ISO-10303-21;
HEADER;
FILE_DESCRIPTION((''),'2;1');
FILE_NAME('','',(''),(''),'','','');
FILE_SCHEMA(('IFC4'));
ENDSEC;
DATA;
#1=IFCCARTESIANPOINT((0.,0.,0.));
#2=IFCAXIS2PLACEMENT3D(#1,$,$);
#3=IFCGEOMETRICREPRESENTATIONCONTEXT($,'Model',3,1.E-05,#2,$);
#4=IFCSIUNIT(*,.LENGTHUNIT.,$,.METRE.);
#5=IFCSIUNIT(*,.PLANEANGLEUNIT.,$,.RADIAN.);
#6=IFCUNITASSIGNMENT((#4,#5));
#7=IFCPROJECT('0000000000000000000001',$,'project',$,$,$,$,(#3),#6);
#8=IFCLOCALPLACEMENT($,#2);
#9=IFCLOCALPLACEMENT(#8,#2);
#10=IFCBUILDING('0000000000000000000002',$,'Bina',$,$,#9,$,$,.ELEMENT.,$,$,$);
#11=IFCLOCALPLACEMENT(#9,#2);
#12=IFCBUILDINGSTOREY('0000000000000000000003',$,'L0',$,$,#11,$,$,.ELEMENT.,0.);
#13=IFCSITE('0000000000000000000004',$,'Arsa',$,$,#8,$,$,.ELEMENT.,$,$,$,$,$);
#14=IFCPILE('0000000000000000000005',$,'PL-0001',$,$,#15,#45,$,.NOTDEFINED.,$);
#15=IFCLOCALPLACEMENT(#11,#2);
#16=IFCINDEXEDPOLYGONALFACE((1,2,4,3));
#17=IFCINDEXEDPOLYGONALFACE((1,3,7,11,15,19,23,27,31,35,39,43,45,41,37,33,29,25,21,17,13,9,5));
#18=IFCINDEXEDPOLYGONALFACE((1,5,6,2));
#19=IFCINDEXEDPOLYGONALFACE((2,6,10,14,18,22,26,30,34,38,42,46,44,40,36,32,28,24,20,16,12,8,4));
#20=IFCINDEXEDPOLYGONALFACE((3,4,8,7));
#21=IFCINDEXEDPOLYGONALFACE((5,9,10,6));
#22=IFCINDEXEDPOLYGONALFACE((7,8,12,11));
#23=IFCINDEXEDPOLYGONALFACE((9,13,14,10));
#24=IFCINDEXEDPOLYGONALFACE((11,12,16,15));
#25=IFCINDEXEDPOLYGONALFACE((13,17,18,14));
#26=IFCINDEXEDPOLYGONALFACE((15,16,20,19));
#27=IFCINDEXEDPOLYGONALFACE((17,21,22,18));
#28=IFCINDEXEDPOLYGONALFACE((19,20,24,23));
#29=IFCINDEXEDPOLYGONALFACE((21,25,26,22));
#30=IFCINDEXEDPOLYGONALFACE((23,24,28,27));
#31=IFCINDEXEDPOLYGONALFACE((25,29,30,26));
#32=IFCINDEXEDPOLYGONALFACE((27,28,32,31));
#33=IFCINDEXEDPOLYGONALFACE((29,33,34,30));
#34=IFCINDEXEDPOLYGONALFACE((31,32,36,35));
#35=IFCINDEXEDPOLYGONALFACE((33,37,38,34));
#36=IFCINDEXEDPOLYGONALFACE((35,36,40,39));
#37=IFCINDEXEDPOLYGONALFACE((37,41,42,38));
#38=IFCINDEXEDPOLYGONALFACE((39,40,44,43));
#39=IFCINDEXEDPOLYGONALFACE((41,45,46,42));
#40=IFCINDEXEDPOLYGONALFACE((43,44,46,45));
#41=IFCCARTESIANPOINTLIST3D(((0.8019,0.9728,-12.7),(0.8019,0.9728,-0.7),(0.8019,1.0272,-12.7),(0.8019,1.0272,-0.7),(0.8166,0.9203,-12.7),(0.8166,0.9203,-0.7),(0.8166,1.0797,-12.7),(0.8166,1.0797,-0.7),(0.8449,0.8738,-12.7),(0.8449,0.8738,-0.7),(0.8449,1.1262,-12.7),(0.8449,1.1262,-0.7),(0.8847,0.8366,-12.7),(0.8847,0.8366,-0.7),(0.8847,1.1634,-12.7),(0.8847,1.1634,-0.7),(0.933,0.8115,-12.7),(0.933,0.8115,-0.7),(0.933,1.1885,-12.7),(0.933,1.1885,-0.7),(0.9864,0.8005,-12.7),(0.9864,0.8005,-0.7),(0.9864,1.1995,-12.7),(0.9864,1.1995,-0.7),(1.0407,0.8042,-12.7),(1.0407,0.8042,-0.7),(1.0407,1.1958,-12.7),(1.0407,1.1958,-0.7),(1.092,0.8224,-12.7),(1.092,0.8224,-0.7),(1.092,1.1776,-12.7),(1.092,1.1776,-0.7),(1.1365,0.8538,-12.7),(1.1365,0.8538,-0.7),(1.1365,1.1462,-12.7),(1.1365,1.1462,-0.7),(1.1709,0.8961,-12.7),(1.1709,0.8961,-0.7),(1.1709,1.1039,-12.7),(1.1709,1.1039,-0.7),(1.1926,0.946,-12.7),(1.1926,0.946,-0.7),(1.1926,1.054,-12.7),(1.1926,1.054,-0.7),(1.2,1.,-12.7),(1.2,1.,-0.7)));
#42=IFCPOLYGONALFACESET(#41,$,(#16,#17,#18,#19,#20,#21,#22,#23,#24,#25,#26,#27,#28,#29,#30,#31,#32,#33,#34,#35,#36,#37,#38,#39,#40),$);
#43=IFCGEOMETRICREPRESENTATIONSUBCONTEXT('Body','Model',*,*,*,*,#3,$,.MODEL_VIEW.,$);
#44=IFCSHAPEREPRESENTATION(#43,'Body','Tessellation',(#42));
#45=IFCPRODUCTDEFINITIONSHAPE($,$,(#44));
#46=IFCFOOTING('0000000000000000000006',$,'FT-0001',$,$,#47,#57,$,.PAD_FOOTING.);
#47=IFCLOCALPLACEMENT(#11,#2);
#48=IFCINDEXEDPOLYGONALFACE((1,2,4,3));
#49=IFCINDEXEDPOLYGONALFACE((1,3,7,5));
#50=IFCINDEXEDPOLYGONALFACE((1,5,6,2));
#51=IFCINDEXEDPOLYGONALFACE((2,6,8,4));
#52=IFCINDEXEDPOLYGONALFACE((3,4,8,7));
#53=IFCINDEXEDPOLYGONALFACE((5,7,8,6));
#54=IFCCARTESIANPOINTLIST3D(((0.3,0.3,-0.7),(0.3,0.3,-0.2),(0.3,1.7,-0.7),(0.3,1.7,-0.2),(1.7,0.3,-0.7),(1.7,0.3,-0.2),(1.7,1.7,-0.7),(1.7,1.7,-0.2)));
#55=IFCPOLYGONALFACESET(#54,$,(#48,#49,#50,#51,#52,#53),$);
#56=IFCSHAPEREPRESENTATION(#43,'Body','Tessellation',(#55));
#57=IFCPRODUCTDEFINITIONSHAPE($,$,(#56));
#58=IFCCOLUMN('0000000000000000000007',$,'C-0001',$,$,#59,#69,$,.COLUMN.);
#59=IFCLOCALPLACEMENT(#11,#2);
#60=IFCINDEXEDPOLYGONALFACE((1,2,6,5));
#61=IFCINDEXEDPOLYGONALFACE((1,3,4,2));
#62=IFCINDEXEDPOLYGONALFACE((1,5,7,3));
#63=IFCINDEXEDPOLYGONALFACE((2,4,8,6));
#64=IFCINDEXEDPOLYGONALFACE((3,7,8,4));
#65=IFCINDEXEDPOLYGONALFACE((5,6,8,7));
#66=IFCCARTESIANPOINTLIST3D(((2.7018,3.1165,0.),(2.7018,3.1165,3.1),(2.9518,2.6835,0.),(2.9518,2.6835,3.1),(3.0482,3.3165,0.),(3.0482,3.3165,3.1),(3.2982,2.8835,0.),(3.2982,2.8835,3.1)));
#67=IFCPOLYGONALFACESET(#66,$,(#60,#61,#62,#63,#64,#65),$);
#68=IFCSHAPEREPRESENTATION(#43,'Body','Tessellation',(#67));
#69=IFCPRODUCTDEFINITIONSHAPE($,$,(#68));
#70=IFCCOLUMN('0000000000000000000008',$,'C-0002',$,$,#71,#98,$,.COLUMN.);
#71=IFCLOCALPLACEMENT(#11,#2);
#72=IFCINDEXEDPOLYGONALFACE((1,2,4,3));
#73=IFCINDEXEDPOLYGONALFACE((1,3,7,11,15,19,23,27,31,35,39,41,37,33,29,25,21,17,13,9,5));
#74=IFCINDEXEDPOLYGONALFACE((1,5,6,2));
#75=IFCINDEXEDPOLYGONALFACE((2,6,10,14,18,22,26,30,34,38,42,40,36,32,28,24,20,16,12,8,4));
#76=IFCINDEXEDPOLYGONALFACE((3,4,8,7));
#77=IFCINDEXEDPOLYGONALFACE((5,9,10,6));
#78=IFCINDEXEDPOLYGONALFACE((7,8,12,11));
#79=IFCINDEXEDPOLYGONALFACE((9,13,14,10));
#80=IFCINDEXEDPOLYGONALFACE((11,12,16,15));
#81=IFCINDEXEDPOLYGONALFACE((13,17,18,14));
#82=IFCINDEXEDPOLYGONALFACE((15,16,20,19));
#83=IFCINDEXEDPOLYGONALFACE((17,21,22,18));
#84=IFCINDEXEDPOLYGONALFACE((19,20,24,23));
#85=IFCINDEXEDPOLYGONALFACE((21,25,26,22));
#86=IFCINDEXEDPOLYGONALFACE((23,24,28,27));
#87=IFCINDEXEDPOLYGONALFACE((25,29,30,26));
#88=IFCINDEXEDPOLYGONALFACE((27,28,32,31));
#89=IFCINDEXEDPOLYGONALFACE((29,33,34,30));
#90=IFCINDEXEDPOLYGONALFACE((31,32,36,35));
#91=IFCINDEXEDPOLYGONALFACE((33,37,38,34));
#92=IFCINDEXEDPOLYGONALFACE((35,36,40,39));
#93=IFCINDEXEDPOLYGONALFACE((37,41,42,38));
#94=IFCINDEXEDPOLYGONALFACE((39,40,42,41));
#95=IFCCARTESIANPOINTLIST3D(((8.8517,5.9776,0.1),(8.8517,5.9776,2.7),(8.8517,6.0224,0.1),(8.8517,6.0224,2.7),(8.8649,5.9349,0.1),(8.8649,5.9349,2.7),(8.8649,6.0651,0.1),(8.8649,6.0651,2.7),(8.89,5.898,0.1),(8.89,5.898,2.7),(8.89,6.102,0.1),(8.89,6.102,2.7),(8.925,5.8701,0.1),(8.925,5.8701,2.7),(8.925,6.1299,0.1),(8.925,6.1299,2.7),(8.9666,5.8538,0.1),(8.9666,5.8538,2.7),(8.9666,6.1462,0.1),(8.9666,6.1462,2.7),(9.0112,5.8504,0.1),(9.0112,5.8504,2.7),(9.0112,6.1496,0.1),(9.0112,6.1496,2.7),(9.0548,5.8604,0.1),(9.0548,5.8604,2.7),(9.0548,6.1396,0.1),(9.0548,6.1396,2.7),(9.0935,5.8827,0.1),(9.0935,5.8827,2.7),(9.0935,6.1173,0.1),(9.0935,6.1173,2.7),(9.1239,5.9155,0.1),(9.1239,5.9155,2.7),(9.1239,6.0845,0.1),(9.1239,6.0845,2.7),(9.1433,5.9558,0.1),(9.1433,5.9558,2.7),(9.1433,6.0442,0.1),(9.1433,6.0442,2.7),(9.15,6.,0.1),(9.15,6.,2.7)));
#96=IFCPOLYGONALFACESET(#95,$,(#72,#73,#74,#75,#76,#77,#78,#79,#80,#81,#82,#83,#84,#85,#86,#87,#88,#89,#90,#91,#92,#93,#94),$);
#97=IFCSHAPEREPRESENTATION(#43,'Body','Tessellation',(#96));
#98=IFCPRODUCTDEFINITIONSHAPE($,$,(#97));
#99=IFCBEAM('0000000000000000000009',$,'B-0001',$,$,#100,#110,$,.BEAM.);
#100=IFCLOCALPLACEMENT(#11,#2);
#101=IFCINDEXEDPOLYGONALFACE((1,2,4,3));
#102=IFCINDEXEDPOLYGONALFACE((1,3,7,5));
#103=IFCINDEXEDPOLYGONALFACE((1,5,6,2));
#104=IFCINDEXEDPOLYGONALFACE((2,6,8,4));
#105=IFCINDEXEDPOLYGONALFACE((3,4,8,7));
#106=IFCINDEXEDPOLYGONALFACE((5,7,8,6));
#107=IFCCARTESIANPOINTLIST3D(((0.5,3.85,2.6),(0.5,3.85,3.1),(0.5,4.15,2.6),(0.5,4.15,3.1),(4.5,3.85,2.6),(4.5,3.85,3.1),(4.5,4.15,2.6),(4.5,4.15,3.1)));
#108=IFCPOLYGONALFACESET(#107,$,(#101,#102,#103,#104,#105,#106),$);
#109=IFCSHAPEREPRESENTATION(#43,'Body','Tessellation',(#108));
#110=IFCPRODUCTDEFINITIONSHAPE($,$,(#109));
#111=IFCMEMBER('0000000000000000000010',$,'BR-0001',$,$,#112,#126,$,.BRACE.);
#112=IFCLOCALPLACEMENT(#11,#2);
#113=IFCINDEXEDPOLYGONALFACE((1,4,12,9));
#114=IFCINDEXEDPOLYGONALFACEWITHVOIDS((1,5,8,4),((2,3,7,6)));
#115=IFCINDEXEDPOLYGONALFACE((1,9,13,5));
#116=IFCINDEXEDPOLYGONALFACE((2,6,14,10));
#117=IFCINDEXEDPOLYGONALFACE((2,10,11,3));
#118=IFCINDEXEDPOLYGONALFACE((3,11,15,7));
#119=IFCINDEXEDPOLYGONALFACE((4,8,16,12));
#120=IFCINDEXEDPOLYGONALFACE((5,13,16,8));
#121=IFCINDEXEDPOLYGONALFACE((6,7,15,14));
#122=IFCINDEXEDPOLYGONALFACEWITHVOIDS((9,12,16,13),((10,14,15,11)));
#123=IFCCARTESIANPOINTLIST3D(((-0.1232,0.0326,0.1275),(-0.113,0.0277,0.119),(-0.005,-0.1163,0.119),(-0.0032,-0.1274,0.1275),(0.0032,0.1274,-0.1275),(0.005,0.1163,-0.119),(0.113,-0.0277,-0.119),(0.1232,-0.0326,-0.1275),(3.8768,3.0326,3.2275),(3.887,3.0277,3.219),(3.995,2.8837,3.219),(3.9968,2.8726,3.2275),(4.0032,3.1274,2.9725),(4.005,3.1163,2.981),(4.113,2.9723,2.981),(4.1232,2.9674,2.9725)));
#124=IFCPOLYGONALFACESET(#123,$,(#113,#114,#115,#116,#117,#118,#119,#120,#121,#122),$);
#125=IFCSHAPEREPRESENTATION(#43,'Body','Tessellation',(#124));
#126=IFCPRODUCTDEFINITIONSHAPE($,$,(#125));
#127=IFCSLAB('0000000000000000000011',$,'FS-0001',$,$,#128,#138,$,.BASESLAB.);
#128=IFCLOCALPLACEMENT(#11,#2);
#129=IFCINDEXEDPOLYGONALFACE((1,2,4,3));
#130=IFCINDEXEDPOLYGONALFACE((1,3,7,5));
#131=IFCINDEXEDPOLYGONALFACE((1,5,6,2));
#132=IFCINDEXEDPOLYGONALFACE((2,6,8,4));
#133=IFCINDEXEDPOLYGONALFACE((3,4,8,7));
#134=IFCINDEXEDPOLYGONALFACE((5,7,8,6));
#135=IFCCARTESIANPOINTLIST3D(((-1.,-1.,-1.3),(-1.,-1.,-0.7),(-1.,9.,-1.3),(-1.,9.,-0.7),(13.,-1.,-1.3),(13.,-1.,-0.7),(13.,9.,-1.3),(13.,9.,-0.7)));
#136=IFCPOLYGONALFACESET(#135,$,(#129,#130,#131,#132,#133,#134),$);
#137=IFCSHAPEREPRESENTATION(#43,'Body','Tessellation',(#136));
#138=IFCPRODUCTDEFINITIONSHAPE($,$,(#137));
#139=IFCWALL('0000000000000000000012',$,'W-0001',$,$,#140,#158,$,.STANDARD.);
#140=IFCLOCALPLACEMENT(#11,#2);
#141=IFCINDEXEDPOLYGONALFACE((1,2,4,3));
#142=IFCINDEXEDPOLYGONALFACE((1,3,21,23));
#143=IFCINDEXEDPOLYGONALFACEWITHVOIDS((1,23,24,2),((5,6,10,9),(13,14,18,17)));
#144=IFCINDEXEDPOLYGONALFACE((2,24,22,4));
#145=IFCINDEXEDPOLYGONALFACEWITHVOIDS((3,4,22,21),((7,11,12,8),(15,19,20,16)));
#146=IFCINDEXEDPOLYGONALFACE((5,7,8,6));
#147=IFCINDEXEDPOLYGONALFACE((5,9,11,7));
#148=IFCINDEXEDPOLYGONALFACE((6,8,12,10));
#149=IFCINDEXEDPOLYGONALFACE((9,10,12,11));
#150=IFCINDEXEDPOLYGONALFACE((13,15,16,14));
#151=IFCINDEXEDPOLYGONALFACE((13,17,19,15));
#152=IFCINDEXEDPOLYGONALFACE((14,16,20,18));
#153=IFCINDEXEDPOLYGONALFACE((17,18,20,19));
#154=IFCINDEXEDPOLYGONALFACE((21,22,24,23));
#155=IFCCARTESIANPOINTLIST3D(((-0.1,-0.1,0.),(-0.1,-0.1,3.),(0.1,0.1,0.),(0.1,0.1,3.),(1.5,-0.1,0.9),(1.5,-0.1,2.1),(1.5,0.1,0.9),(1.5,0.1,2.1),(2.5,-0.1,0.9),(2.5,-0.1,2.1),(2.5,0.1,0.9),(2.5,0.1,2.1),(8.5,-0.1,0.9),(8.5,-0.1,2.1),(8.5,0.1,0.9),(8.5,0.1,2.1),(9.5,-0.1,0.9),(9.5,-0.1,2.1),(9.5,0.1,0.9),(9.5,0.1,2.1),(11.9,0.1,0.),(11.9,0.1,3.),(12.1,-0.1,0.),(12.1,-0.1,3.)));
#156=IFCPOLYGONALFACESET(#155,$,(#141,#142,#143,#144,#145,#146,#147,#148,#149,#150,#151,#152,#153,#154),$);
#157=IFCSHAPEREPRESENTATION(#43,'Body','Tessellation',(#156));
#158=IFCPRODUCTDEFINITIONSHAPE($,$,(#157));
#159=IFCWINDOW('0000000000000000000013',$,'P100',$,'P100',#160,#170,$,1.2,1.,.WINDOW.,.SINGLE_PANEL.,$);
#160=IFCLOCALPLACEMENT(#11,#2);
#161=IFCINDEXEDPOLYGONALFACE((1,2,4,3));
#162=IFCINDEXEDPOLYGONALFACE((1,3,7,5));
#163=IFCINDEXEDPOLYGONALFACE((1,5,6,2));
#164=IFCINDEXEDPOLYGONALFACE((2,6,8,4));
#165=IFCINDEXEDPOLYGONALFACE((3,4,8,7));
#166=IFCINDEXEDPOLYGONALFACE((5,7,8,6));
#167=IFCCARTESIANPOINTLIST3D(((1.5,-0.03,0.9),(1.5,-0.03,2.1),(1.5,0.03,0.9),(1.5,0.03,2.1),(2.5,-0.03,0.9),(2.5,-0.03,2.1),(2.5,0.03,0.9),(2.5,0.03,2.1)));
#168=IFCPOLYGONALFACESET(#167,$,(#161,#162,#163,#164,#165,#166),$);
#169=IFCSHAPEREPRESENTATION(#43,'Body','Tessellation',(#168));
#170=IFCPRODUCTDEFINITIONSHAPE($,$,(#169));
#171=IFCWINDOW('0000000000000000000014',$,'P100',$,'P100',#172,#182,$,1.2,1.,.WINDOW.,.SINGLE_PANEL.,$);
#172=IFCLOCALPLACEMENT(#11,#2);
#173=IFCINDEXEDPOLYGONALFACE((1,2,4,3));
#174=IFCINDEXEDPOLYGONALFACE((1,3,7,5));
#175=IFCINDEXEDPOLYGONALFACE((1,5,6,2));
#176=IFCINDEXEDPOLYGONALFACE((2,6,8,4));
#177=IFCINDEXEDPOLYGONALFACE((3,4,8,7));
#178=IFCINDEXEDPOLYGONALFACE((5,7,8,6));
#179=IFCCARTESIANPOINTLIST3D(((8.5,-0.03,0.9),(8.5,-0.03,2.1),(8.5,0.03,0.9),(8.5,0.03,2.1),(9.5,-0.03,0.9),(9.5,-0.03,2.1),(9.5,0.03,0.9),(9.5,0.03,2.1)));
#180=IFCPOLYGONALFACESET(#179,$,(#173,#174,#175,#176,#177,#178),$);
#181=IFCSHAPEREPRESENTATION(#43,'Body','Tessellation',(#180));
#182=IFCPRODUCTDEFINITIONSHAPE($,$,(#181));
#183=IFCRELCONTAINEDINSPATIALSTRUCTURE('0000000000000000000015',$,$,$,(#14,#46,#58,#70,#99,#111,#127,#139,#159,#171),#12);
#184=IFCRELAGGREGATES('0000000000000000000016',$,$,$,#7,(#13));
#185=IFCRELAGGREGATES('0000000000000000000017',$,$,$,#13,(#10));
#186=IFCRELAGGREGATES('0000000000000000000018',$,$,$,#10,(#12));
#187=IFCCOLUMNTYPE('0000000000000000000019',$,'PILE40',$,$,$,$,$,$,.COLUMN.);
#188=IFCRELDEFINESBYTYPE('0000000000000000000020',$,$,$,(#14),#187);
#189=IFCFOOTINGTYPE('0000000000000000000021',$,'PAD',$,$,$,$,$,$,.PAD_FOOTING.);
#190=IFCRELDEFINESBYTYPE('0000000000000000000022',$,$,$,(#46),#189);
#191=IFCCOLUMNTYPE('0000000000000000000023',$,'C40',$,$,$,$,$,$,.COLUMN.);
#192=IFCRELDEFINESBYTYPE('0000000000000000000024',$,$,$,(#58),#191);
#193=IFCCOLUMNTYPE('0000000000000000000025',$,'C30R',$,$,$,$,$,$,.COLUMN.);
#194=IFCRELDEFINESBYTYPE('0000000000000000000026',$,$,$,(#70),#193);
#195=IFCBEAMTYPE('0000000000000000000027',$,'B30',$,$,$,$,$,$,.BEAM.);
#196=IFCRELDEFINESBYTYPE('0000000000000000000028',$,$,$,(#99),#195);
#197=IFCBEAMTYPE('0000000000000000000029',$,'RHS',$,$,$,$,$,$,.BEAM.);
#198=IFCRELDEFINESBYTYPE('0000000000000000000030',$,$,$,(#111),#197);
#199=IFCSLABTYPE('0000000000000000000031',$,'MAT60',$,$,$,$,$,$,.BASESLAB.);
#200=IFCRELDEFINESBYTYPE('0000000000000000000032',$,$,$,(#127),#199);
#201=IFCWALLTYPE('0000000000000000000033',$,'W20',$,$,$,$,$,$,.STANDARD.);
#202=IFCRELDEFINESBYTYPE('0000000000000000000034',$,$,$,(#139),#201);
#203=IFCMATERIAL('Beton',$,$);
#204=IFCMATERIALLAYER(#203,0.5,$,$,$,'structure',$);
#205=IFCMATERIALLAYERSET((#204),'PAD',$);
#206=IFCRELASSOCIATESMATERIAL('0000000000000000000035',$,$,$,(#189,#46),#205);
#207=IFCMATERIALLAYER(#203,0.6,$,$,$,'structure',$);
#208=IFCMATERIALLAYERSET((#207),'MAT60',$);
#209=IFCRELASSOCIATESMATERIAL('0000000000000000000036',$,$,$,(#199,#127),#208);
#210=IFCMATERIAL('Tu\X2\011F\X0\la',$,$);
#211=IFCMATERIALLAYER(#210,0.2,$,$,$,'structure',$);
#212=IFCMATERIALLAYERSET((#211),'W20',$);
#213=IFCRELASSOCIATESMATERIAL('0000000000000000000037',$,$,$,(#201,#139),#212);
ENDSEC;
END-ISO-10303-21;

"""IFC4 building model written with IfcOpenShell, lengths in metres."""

from ifc_helpers import new_model, si_unit, frame, frame_2d, origin, origin_with_axes, origin_2d, place, context, subcontext, project, spatial, polyline, rectangle, hollow_rectangle, circle, outline, extrude, material, layer, layer_set, layer_usage, type_object, element, fill, save


model = new_model("IFC4")

# Units and contexts
model_context = context("Model", 3, precision=1e-05, world=origin())
body_context = subcontext(model_context, "Body", "Model", "MODEL_VIEW")
ifc_project = project(units=[si_unit("LENGTHUNIT", "METRE"), si_unit("PLANEANGLEUNIT", "RADIAN")], contexts=[model_context])

# Site, building, storey
site_placement = place(None, origin())
site = spatial("IfcSite", under=ifc_project, at=site_placement, Name="Arsa", CompositionType="ELEMENT")
building_placement = place(site_placement, origin())
building = spatial("IfcBuilding", under=site, at=building_placement, Name="Bina", CompositionType="ELEMENT")
storey_placement = place(building_placement, origin())
storey = spatial("IfcBuildingStorey", under=building, at=storey_placement, Name="L0", CompositionType="ELEMENT", Elevation=0.0)

# Pile
column_type_1 = type_object("IfcColumnType", Name="PILE40", PredefinedType="COLUMN")
pile_placement = place(storey_placement, origin())
element("IfcPile", 1, at=pile_placement, inside=storey, type_object=column_type_1, Name="PL-0001", PredefinedType="NOTDEFINED", context=body_context, shape_type="SweptSolid", body=[
    extrude(circle(Radius=0.2, at=origin_2d()), frame((1.0, 1.0, -0.7), z_axis=(0.0, 0.0, -1.0), x_axis=(1.0, 0.0, 0.0)), (0.0, 0.0, 1.0), 12.0),
])

# Footing
ifc_material_1 = material(Name="Beton")
ifc_layer_1 = layer(ifc_material_1, 0.5, Category="structure")
ifc_layer_set_1 = layer_set([ifc_layer_1], Name="PAD")
ifc_layer_usage_1 = layer_usage(ifc_layer_set_1, "AXIS3", "NEGATIVE", -0.2)
footing_type = type_object("IfcFootingType", Name="PAD", PredefinedType="PAD_FOOTING", material=ifc_layer_set_1)
footing_placement = place(storey_placement, origin())
element("IfcFooting", 2, at=footing_placement, inside=storey, type_object=footing_type, material=ifc_layer_usage_1, Name="FT-0001", PredefinedType="PAD_FOOTING", context=body_context, shape_type="SweptSolid", body=[
    extrude(outline(polyline([(0.3, 0.3), (1.7, 0.3), (1.7, 1.7), (0.3, 1.7), (0.3, 0.3)])), frame((0.0, 0.0, -0.7)), (0.0, 0.0, 1.0), 0.5),
])

# Columns
column_type_2 = type_object("IfcColumnType", Name="C40", PredefinedType="COLUMN")
column_1_placement = place(storey_placement, origin())
element("IfcColumn", 3, at=column_1_placement, inside=storey, type_object=column_type_2, Name="C-0001", PredefinedType="COLUMN", context=body_context, shape_type="SweptSolid", body=[
    extrude(rectangle(XDim=0.4, YDim=0.5, at=origin_2d()), frame((3.0, 3.0, 0.0), z_axis=(0.0, 0.0, 1.0), x_axis=(0.866025, 0.5, 0.0)), (0.0, 0.0, 1.0), 3.1),
])
column_type_3 = type_object("IfcColumnType", Name="C30R", PredefinedType="COLUMN")
column_2_placement = place(storey_placement, origin())
element("IfcColumn", 4, at=column_2_placement, inside=storey, type_object=column_type_3, Name="C-0002", PredefinedType="COLUMN", context=body_context, shape_type="SweptSolid", body=[
    extrude(circle(Radius=0.15, at=origin_2d()), frame((9.0, 6.0, 0.1), z_axis=(0.0, 0.0, 1.0), x_axis=(1.0, 0.0, 0.0)), (0.0, 0.0, 1.0), 2.6),
])

# Beam
beam_type_1 = type_object("IfcBeamType", Name="B30", PredefinedType="BEAM")
beam_placement = place(storey_placement, origin())
element("IfcBeam", 5, at=beam_placement, inside=storey, type_object=beam_type_1, Name="B-0001", PredefinedType="BEAM", context=body_context, shape_type="SweptSolid", body=[
    extrude(rectangle(XDim=0.3, YDim=0.5, at=frame_2d((0.0, -0.25))), frame((0.5, 4.0, 3.1), z_axis=(1.0, 0.0, 0.0), x_axis=(0.0, 1.0, 0.0)), (0.0, 0.0, 1.0), 4.0),
])

# Member
beam_type_2 = type_object("IfcBeamType", Name="RHS", PredefinedType="BEAM")
member_placement = place(storey_placement, origin())
element("IfcMember", 6, at=member_placement, inside=storey, type_object=beam_type_2, Name="BR-0001", PredefinedType="BRACE", context=body_context, shape_type="SweptSolid", body=[
    extrude(hollow_rectangle(XDim=0.2, YDim=0.3, WallThickness=0.01, at=origin_2d()), frame((0.0, 0.0, 0.0), z_axis=(0.679922, 0.509942, 0.52694), x_axis=(-0.6, 0.8, 0.0)), (0.0, 0.0, 1.0), 5.883),
])

# Slab
ifc_layer_2 = layer(ifc_material_1, 0.6, Category="structure")
ifc_layer_set_2 = layer_set([ifc_layer_2], Name="MAT60")
ifc_layer_usage_2 = layer_usage(ifc_layer_set_2, "AXIS3", "NEGATIVE", -0.7)
slab_type = type_object("IfcSlabType", Name="MAT60", PredefinedType="BASESLAB", material=ifc_layer_set_2)
slab_placement = place(storey_placement, origin())
element("IfcSlab", 7, at=slab_placement, inside=storey, type_object=slab_type, material=ifc_layer_usage_2, Name="FS-0001", PredefinedType="BASESLAB", context=body_context, shape_type="SweptSolid", body=[
    extrude(outline(polyline([(-1.0, -1.0), (13.0, -1.0), (13.0, 9.0), (-1.0, 9.0), (-1.0, -1.0)])), frame((0.0, 0.0, -1.3)), (0.0, 0.0, 1.0), 0.6),
])

# Wall, openings, windows
ifc_material_2 = material(Name="Tuğla")
ifc_layer_3 = layer(ifc_material_2, 0.2, Category="structure")
ifc_layer_set_3 = layer_set([ifc_layer_3], Name="W20")
ifc_layer_usage_3 = layer_usage(ifc_layer_set_3, "AXIS2", "POSITIVE", -0.1)
wall_type_1 = type_object("IfcWallType", Name="W20", PredefinedType="STANDARD", material=ifc_layer_set_3)
wall_1_placement = place(storey_placement, origin_with_axes())
wall_1 = element("IfcWall", 8, at=wall_1_placement, inside=storey, type_object=wall_type_1, material=ifc_layer_usage_3, Name="W-0001", PredefinedType="STANDARD", context=body_context, shape_type="SweptSolid", body=[
    extrude(outline(polyline([(0.1, 0.1), (11.9, 0.1), (12.1, -0.1), (-0.1, -0.1), (0.1, 0.1)])), origin(), (0.0, 0.0, 1.0), 3.0),
])
opening_1_placement = place(wall_1_placement, frame((2.0, 0.0, 0.9)))
opening_1 = element("IfcOpeningElement", 9, at=opening_1_placement, cuts=wall_1, PredefinedType="OPENING", context=body_context, shape_type="SweptSolid", body=[
    extrude(rectangle(XDim=1.0, YDim=0.3, at=origin_2d()), origin(), (0.0, 0.0, 1.0), 1.2),
])
opening_2_placement = place(wall_1_placement, frame((9.0, 0.0, 0.9)))
opening_2 = element("IfcOpeningElement", 10, at=opening_2_placement, cuts=wall_1, PredefinedType="OPENING", context=body_context, shape_type="SweptSolid", body=[
    extrude(rectangle(XDim=1.0, YDim=0.3, at=origin_2d()), origin(), (0.0, 0.0, 1.0), 1.2),
])
window_1_placement = place(opening_1_placement, origin())
window_1 = element("IfcWindow", 11, at=window_1_placement, inside=storey, Name="P100", ObjectType="P100", OverallHeight=1.2, OverallWidth=1.0, PartitioningType="SINGLE_PANEL", PredefinedType="WINDOW", context=body_context, shape_type="SweptSolid", body=[
    extrude(rectangle(XDim=1.0, YDim=0.06, at=origin_2d()), origin(), (0.0, 0.0, 1.0), 1.2),
])
fill(opening_1, window_1)
window_2_placement = place(opening_2_placement, origin())
window_2 = element("IfcWindow", 12, at=window_2_placement, inside=storey, Name="P100", ObjectType="P100", OverallHeight=1.2, OverallWidth=1.0, PartitioningType="SINGLE_PANEL", PredefinedType="WINDOW", context=body_context, shape_type="SweptSolid", body=[
    extrude(rectangle(XDim=1.0, YDim=0.06, at=origin_2d()), origin(), (0.0, 0.0, 1.0), 1.2),
])
fill(opening_2, window_2)

save(model, "model.ifc")
